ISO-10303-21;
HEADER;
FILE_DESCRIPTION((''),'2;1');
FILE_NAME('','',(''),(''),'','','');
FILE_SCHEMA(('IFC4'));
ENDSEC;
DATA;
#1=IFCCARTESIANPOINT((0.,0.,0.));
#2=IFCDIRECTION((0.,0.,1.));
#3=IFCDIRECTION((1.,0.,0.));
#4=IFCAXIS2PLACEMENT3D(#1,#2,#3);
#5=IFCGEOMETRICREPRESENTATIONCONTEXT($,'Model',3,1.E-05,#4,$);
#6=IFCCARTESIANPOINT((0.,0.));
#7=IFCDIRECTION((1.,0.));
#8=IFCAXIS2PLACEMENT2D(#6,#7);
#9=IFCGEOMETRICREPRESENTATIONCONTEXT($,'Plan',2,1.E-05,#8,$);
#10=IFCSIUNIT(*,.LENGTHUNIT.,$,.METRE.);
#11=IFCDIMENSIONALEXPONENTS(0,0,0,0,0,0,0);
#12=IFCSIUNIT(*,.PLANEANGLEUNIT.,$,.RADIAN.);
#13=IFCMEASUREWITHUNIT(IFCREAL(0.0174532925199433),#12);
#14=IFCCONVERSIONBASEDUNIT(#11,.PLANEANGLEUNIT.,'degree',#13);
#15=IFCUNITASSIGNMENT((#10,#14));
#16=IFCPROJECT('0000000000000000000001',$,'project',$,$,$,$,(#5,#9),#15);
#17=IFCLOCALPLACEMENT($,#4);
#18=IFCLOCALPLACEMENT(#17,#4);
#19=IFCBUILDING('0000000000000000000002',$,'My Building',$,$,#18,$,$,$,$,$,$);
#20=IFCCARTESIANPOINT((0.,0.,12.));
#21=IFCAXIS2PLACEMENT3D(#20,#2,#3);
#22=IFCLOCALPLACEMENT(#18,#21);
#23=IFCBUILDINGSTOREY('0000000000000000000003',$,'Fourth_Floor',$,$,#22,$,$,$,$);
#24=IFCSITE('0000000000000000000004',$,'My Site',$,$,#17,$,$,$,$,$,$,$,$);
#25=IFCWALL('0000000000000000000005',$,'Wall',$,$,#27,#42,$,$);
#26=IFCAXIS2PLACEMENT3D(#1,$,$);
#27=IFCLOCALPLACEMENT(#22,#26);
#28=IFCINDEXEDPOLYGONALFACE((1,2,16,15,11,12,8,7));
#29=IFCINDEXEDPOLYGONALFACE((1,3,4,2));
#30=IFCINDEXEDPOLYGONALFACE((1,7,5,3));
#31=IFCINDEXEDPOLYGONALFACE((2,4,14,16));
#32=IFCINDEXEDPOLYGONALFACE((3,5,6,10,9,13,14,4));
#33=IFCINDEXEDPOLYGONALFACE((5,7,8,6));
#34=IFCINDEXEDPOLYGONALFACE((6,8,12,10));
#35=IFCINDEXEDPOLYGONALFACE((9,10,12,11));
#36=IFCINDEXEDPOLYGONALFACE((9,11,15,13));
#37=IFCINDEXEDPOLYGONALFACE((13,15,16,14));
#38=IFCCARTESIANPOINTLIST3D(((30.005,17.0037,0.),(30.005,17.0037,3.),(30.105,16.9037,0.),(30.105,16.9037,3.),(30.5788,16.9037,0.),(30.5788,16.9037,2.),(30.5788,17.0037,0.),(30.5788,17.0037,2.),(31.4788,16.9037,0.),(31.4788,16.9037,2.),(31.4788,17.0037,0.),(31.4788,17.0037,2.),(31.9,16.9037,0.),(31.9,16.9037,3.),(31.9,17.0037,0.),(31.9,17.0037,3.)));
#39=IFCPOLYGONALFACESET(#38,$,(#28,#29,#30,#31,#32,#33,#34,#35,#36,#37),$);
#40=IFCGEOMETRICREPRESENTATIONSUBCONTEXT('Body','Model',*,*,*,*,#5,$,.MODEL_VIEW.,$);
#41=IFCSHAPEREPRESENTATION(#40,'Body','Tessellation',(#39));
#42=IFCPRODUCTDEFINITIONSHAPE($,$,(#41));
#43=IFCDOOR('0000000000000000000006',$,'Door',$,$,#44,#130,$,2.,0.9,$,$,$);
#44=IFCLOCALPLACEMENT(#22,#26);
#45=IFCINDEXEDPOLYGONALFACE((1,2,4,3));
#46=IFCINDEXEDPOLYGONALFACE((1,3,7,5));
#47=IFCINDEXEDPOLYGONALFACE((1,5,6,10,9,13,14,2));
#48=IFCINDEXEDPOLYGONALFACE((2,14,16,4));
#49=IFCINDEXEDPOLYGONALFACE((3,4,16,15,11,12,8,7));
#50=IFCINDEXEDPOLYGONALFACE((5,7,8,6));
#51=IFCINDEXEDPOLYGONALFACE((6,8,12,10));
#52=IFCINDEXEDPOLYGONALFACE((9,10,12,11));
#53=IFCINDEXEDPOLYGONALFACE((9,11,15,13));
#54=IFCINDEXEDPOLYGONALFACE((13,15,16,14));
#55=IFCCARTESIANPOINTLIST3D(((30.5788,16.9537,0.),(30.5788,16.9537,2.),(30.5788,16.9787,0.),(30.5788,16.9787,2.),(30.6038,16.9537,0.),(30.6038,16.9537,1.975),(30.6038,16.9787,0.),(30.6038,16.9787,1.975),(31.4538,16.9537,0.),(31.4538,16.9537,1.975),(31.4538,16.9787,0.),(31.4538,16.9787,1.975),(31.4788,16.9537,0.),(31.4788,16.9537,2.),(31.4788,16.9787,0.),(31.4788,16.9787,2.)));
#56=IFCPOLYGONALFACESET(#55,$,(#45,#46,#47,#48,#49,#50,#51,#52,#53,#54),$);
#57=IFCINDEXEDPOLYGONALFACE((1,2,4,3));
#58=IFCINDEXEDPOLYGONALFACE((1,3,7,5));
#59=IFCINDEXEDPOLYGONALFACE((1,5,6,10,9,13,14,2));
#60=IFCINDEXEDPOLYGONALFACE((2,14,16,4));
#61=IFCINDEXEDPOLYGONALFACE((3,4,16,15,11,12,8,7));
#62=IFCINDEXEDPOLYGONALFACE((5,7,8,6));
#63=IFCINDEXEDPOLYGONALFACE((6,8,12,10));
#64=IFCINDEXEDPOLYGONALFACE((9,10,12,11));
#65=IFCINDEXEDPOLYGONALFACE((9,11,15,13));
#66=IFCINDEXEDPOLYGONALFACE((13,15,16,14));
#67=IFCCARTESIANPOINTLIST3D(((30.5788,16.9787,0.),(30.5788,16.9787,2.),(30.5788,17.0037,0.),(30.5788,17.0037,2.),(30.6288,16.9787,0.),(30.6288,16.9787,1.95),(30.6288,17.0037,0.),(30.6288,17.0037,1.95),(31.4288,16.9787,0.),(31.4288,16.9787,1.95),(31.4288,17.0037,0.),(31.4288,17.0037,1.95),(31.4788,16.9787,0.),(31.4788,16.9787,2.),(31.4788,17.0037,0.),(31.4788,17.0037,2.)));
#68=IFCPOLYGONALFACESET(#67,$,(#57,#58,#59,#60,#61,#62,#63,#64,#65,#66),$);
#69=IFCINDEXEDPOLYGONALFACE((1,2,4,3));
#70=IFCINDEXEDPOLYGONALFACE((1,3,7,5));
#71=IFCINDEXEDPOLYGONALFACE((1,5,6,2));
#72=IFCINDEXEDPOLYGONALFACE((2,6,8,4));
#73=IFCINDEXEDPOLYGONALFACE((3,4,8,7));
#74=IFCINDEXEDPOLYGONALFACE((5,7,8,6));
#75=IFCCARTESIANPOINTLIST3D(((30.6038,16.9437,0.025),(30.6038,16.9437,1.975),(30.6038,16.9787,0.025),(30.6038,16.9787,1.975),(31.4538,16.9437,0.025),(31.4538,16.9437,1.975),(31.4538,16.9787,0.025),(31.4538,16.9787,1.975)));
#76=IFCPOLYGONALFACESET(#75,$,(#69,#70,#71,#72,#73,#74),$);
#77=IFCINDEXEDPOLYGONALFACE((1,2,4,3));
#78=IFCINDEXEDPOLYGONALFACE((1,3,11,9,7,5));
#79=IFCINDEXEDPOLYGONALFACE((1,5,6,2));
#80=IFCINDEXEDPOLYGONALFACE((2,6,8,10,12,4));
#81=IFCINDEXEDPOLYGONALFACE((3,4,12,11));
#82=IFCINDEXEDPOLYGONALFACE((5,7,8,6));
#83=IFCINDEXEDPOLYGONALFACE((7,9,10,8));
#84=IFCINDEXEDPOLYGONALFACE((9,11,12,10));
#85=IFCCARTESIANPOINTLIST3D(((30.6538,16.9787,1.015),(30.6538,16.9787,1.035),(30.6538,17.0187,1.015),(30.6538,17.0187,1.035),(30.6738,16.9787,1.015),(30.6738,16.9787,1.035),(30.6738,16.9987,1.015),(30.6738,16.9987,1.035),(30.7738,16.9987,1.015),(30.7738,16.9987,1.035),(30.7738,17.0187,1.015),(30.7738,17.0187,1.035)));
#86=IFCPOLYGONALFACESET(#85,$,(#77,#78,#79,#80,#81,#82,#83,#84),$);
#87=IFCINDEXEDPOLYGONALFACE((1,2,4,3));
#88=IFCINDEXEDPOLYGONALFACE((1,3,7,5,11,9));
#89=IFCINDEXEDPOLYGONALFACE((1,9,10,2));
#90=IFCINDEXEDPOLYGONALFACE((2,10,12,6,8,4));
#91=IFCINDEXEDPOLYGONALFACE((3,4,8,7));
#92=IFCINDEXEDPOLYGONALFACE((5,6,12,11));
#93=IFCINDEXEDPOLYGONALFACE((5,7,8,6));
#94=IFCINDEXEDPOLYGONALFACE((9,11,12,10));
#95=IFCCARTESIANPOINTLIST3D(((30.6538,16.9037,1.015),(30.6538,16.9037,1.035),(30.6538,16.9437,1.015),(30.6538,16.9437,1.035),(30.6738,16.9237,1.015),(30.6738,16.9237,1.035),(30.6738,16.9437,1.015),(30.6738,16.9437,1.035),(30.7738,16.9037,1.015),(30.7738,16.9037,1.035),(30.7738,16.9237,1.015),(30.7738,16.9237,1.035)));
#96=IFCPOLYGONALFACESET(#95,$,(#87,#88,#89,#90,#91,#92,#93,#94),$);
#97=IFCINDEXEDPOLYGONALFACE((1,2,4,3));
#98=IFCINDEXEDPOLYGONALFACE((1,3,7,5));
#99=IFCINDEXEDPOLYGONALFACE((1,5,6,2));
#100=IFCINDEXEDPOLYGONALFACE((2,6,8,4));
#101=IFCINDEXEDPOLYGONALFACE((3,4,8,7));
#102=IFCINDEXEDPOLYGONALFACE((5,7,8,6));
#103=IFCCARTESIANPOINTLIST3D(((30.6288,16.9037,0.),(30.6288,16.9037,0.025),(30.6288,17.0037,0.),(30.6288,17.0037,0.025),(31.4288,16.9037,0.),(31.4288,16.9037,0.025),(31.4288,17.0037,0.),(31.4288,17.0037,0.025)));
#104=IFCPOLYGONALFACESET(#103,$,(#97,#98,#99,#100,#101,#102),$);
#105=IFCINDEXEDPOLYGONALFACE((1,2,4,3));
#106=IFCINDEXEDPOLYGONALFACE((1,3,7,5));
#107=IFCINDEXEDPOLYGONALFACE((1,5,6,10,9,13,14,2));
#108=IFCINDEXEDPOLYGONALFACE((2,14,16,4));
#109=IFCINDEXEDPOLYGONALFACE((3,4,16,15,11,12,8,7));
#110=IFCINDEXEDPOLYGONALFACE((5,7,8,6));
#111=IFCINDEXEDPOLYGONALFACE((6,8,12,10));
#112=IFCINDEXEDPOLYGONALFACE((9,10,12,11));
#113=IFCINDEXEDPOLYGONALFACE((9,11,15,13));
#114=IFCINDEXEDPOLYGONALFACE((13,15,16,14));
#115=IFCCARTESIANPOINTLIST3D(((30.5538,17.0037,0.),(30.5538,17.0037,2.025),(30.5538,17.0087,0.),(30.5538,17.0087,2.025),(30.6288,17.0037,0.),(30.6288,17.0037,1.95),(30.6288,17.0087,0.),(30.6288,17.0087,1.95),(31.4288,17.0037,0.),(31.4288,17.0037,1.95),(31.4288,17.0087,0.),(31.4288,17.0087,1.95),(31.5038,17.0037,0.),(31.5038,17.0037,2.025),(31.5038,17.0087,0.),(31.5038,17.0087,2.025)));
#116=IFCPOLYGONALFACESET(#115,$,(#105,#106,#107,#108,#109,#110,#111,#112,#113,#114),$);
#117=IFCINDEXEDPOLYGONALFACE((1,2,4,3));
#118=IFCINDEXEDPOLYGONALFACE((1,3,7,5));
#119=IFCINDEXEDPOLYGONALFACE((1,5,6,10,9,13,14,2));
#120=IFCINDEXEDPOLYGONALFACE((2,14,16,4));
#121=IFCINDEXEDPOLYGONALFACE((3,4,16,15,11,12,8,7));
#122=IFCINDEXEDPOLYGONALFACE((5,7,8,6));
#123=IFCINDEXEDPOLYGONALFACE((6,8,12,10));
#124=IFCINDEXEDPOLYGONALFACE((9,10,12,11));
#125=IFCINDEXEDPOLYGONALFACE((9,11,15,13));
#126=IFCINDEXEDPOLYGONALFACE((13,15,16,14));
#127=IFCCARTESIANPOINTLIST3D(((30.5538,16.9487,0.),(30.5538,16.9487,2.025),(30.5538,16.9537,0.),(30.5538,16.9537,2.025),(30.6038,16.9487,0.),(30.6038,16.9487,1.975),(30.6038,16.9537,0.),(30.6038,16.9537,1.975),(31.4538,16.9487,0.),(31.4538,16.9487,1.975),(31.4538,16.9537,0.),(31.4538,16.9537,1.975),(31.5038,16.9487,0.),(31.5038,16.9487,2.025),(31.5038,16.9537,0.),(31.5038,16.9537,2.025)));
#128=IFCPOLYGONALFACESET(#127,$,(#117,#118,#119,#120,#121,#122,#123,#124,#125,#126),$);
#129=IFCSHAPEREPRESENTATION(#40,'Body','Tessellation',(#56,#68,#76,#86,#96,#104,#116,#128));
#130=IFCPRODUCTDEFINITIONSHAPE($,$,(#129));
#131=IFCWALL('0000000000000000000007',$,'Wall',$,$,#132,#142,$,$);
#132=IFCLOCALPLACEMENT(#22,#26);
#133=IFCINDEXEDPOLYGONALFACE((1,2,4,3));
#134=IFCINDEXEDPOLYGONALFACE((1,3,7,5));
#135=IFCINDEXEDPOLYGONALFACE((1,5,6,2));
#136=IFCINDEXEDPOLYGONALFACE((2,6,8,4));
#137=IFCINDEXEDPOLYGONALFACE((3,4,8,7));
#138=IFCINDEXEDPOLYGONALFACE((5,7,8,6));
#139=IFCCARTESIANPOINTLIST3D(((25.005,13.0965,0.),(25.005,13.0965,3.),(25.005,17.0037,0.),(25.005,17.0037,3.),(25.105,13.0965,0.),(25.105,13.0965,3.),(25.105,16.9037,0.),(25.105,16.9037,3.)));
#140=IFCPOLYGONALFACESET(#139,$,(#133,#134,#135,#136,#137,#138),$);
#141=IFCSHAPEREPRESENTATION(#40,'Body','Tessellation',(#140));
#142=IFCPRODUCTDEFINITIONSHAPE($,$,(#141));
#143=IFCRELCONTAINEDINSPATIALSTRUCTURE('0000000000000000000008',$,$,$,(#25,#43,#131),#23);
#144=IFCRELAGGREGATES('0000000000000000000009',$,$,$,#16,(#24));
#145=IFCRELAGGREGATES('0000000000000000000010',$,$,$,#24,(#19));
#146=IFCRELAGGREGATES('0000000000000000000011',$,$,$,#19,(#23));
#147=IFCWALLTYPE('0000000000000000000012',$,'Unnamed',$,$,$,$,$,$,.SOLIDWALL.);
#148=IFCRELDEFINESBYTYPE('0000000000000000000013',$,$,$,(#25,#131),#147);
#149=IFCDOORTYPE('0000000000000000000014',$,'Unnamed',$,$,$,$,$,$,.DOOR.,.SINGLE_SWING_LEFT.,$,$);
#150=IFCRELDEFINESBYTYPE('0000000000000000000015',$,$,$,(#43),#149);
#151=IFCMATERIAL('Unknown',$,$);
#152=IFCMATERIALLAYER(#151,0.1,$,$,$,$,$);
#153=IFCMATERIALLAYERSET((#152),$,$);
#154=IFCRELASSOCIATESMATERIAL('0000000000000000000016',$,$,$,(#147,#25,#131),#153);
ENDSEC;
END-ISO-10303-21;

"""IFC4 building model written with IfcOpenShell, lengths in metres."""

from ifc_helpers import new_model, entity, si_unit, converted_unit, frame, origin_with_axes, origin_2d_with_axis, place, context, subcontext, project, spatial, line, indexed_curve, outline, extrude, shape, source, transform, mapped, material, layer, layer_set, layer_usage, type_object, type_shapes, element, fill, save


model = new_model("IFC4")

# Units and contexts
model_context = context("Model", 3, precision=1e-05, world=origin_with_axes())
plan_context = context("Plan", 2, precision=1e-05, world=origin_2d_with_axis())
body_context_1 = subcontext(model_context, "Body", "Model", "MODEL_VIEW")
body_context_2 = subcontext(plan_context, "Body", "Plan", "PLAN_VIEW")
ifc_project = project(units=[si_unit("LENGTHUNIT", "METRE"), converted_unit("PLANEANGLEUNIT", "degree", entity("IfcReal", 0.0174532925199433), si_unit("PLANEANGLEUNIT", "RADIAN"), dimensions=[0, 0, 0, 0, 0, 0, 0])], contexts=[model_context, plan_context])

# Site, building, storey
site_placement = place(None, origin_with_axes())
site = spatial("IfcSite", under=ifc_project, at=site_placement, Name="My Site")
building_placement = place(site_placement, origin_with_axes())
building = spatial("IfcBuilding", under=site, at=building_placement, Name="My Building")
storey_placement = place(building_placement, frame((0.0, 0.0, 12.0), z_axis=(0.0, 0.0, 1.0), x_axis=(1.0, 0.0, 0.0)))
storey = spatial("IfcBuildingStorey", under=building, at=storey_placement, Name="Fourth_Floor")

# Shared definitions
ifc_material = material(Name="Unknown")
ifc_layer = layer(ifc_material, 0.1)
ifc_layer_set = layer_set([ifc_layer])
wall_type = type_object("IfcWallType", Name="Unnamed", PredefinedType="SOLIDWALL", material=ifc_layer_set)

# Wall, opening, door
shared_shape_1 = source(origin_with_axes(), body_context_1, "Body", "SweptSolid", [
    extrude(outline(indexed_curve([(0.0, 0.0), (0.9, 0.0), (0.9, 2.0), (0.0, 2.0)], segments=[line(1, 2, 3, 4, 1)])), frame((0.0, -0.6, 0.0), z_axis=(0.0, -1.0, 0.0), x_axis=(1.0, 0.0, 0.0)), (0.0, 0.0, -1.0), 1.2),
])
door_type = type_object("IfcDoorType", Name="Unnamed", OperationType="SINGLE_SWING_LEFT", PredefinedType="DOOR")
shared_shape_2 = source(origin_with_axes(), body_context_1, "Body", "SweptSolid", [
    extrude(outline(indexed_curve([(0.0, 0.0), (0.0, 2.0), (0.9, 2.0), (0.9, 0.0), (0.875, 0.0), (0.875, 1.975), (0.025, 1.975), (0.025, 0.0)], segments=[line(1, 2, 3, 4, 5, 6, 7, 8, 1)])), frame((0.0, 0.025, 0.0), z_axis=(0.0, -1.0, 0.0), x_axis=(1.0, 0.0, 0.0)), (0.0, 0.0, -1.0), 0.025),
    extrude(outline(indexed_curve([(0.0, 0.0), (0.0, 2.0), (0.9, 2.0), (0.9, 0.0), (0.85, 0.0), (0.85, 1.95), (0.05, 1.95), (0.05, 0.0)], segments=[line(1, 2, 3, 4, 5, 6, 7, 8, 1)])), frame((0.0, 0.0, 0.0), z_axis=(0.0, -1.0, 0.0), x_axis=(1.0, 0.0, 0.0)), (0.0, 0.0, -1.0), 0.025),
    extrude(outline(indexed_curve([(0.0, 0.0), (0.85, 0.0), (0.85, 0.035), (0.0, 0.035)], segments=[line(1, 2, 3, 4, 1)])), frame((0.025, 0.025, 0.025), z_axis=(0.0, 0.0, 1.0), x_axis=(1.0, 0.0, 0.0)), (0.0, 0.0, 1.0), 1.95),
    extrude(outline(indexed_curve([(0.0, 0.0), (0.0, -0.04), (-0.12, -0.04), (-0.12, -0.02), (-0.02, -0.02), (-0.02, 0.0)], segments=[line(1, 2, 3, 4, 5, 6, 1)])), frame((0.825, 0.025, 1.015), z_axis=(0.0, 0.0, 1.0), x_axis=(1.0, 0.0, 0.0)), (0.0, 0.0, 1.0), 0.02),
    extrude(outline(indexed_curve([(0.0, 0.0), (0.0, 0.04), (-0.12, 0.04), (-0.12, 0.02), (-0.02, 0.02), (-0.02, 0.0)], segments=[line(1, 2, 3, 4, 5, 6, 1)])), frame((0.825, 0.06, 1.015), z_axis=(0.0, 0.0, 1.0), x_axis=(1.0, 0.0, 0.0)), (0.0, 0.0, 1.0), 0.02),
    extrude(outline(indexed_curve([(0.0, 0.0), (0.8, 0.0), (0.8, 0.1), (0.0, 0.1)], segments=[line(1, 2, 3, 4, 1)])), frame((0.05, 0.0, 0.0), z_axis=(0.0, 0.0, 1.0), x_axis=(1.0, 0.0, 0.0)), (0.0, 0.0, 1.0), 0.025),
    extrude(outline(indexed_curve([(0.0, 0.0), (0.0, 2.025), (0.95, 2.025), (0.95, 0.0), (0.875, 0.0), (0.875, 1.95), (0.075, 1.95), (0.075, 0.0)], segments=[line(1, 2, 3, 4, 5, 6, 7, 8, 1)])), frame((-0.025, -0.005, 0.0), z_axis=(0.0, -1.0, 0.0), x_axis=(1.0, 0.0, 0.0)), (0.0, 0.0, -1.0), 0.005),
    extrude(outline(indexed_curve([(0.0, 0.0), (0.0, 2.025), (0.95, 2.025), (0.95, 0.0), (0.9, 0.0), (0.9, 1.975), (0.05, 1.975), (0.05, 0.0)], segments=[line(1, 2, 3, 4, 5, 6, 7, 8, 1)])), frame((-0.025, 0.05, 0.0), z_axis=(0.0, -1.0, 0.0), x_axis=(1.0, 0.0, 0.0)), (0.0, 0.0, -1.0), 0.005),
])
shared_shape_3 = source(origin_with_axes(), body_context_2, "Body", "Curve2D", [
    entity("IfcIndexedPolyCurve", entity("IfcCartesianPointList2D", [[0.0, 0.0], [0.0, 0.05], [0.025, 0.05], [0.025, 0.025], [0.05, 0.025], [0.05, 0.0]]), [entity("IfcLineIndex", [1, 2, 3, 4, 5, 6, 1])]),
    entity("IfcIndexedPolyCurve", entity("IfcCartesianPointList2D", [[0.9, 0.0], [0.9, 0.05], [0.875, 0.05], [0.875, 0.025], [0.85, 0.025], [0.85, 0.0]]), [entity("IfcLineIndex", [1, 2, 3, 4, 5, 6, 1])]),
    entity("IfcTrimmedCurve", entity("IfcEllipse", entity("IfcAxis2Placement2D", entity("IfcCartesianPoint", [0.06, 0.05]), entity("IfcDirection", [1.0, 0.0])), 0.815, 0.85), [entity("IfcCartesianPoint", [0.875, 0.05])], [entity("IfcCartesianPoint", [0.06, 0.9])], True, "CARTESIAN"),
    entity("IfcIndexedPolyCurve", entity("IfcCartesianPointList2D", [[0.025, 0.05], [0.06, 0.05], [0.06, 0.9], [0.025, 0.9]]), [entity("IfcLineIndex", [1, 2, 3, 4, 1])]),
])
type_shapes(door_type, [shared_shape_2, shared_shape_3])
ifc_layer_usage_1 = layer_usage(ifc_layer_set, "AXIS2", "POSITIVE", 0.0)
wall_1_placement = place(storey_placement, frame((31.9, 17.0037, 0.0), z_axis=(0.0, 0.0, 1.0), x_axis=(-1.0, 0.0, 0.0)))
wall_1 = element("IfcWall", 1, at=wall_1_placement, inside=storey, type_object=wall_type, material=ifc_layer_usage_1, Name="Wall", context=body_context_1, shape_type="SweptSolid", body=[
    extrude(outline(indexed_curve([(0.0, 0.0), (0.0, 0.1), (1.795, 0.1), (1.895, 0.0)], segments=[line(1, 2, 3, 4, 1)])), origin_with_axes(), (0.0, 0.0, 1.0), 3.0),
])
opening_1_placement = place(wall_1_placement, frame((0.4212, 0.0, 0.0), z_axis=(0.0, 0.0, 1.0), x_axis=(1.0, 0.0, 0.0)))
opening_1 = element("IfcOpeningElement", 2, at=opening_1_placement, cuts=wall_1, PredefinedType="OPENING", context=body_context_1, shape_type="MappedRepresentation", body=[
    mapped(shared_shape_1, transform((0.0, 0.0, 0.0), x_axis=(1.0, 0.0, 0.0), y_axis=(0.0, 1.0, 0.0), z_axis=(0.0, 0.0, 1.0), scale=1.0)),
])
door_1_placement = place(opening_1_placement, origin_with_axes())
door_1 = element("IfcDoor", 3, at=door_1_placement, inside=storey, type_object=door_type, Name="Door", OverallHeight=2.0, OverallWidth=0.9, shapes=[
    shape(body_context_1, "Body", "MappedRepresentation", [mapped(shared_shape_2, transform((0.0, 0.0, 0.0), x_axis=(1.0, 0.0, 0.0), y_axis=(0.0, 1.0, 0.0), z_axis=(0.0, 0.0, 1.0), scale=1.0))]),
    shape(body_context_2, "Body", "MappedRepresentation", [mapped(shared_shape_3, transform((0.0, 0.0, 0.0), x_axis=(1.0, 0.0, 0.0), y_axis=(0.0, 1.0, 0.0), z_axis=(0.0, 0.0, 1.0), scale=1.0))]),
])
fill(opening_1, door_1)

# Wall
ifc_layer_usage_2 = layer_usage(ifc_layer_set, "AXIS2", "POSITIVE", 0.0)
wall_2_placement = place(storey_placement, frame((25.005, 17.0037, 0.0), z_axis=(0.0, 0.0, 1.0), x_axis=(0.0, -1.0, 0.0)))
element("IfcWall", 4, at=wall_2_placement, inside=storey, type_object=wall_type, material=ifc_layer_usage_2, Name="Wall", context=body_context_1, shape_type="SweptSolid", body=[
    extrude(outline(indexed_curve([(0.0, 0.0), (0.1, 0.1), (3.9072, 0.1), (3.9072, 0.0)], segments=[line(1, 2, 3, 4, 1)])), origin_with_axes(), (0.0, 0.0, 1.0), 3.0),
])

save(model, "model.ifc")
